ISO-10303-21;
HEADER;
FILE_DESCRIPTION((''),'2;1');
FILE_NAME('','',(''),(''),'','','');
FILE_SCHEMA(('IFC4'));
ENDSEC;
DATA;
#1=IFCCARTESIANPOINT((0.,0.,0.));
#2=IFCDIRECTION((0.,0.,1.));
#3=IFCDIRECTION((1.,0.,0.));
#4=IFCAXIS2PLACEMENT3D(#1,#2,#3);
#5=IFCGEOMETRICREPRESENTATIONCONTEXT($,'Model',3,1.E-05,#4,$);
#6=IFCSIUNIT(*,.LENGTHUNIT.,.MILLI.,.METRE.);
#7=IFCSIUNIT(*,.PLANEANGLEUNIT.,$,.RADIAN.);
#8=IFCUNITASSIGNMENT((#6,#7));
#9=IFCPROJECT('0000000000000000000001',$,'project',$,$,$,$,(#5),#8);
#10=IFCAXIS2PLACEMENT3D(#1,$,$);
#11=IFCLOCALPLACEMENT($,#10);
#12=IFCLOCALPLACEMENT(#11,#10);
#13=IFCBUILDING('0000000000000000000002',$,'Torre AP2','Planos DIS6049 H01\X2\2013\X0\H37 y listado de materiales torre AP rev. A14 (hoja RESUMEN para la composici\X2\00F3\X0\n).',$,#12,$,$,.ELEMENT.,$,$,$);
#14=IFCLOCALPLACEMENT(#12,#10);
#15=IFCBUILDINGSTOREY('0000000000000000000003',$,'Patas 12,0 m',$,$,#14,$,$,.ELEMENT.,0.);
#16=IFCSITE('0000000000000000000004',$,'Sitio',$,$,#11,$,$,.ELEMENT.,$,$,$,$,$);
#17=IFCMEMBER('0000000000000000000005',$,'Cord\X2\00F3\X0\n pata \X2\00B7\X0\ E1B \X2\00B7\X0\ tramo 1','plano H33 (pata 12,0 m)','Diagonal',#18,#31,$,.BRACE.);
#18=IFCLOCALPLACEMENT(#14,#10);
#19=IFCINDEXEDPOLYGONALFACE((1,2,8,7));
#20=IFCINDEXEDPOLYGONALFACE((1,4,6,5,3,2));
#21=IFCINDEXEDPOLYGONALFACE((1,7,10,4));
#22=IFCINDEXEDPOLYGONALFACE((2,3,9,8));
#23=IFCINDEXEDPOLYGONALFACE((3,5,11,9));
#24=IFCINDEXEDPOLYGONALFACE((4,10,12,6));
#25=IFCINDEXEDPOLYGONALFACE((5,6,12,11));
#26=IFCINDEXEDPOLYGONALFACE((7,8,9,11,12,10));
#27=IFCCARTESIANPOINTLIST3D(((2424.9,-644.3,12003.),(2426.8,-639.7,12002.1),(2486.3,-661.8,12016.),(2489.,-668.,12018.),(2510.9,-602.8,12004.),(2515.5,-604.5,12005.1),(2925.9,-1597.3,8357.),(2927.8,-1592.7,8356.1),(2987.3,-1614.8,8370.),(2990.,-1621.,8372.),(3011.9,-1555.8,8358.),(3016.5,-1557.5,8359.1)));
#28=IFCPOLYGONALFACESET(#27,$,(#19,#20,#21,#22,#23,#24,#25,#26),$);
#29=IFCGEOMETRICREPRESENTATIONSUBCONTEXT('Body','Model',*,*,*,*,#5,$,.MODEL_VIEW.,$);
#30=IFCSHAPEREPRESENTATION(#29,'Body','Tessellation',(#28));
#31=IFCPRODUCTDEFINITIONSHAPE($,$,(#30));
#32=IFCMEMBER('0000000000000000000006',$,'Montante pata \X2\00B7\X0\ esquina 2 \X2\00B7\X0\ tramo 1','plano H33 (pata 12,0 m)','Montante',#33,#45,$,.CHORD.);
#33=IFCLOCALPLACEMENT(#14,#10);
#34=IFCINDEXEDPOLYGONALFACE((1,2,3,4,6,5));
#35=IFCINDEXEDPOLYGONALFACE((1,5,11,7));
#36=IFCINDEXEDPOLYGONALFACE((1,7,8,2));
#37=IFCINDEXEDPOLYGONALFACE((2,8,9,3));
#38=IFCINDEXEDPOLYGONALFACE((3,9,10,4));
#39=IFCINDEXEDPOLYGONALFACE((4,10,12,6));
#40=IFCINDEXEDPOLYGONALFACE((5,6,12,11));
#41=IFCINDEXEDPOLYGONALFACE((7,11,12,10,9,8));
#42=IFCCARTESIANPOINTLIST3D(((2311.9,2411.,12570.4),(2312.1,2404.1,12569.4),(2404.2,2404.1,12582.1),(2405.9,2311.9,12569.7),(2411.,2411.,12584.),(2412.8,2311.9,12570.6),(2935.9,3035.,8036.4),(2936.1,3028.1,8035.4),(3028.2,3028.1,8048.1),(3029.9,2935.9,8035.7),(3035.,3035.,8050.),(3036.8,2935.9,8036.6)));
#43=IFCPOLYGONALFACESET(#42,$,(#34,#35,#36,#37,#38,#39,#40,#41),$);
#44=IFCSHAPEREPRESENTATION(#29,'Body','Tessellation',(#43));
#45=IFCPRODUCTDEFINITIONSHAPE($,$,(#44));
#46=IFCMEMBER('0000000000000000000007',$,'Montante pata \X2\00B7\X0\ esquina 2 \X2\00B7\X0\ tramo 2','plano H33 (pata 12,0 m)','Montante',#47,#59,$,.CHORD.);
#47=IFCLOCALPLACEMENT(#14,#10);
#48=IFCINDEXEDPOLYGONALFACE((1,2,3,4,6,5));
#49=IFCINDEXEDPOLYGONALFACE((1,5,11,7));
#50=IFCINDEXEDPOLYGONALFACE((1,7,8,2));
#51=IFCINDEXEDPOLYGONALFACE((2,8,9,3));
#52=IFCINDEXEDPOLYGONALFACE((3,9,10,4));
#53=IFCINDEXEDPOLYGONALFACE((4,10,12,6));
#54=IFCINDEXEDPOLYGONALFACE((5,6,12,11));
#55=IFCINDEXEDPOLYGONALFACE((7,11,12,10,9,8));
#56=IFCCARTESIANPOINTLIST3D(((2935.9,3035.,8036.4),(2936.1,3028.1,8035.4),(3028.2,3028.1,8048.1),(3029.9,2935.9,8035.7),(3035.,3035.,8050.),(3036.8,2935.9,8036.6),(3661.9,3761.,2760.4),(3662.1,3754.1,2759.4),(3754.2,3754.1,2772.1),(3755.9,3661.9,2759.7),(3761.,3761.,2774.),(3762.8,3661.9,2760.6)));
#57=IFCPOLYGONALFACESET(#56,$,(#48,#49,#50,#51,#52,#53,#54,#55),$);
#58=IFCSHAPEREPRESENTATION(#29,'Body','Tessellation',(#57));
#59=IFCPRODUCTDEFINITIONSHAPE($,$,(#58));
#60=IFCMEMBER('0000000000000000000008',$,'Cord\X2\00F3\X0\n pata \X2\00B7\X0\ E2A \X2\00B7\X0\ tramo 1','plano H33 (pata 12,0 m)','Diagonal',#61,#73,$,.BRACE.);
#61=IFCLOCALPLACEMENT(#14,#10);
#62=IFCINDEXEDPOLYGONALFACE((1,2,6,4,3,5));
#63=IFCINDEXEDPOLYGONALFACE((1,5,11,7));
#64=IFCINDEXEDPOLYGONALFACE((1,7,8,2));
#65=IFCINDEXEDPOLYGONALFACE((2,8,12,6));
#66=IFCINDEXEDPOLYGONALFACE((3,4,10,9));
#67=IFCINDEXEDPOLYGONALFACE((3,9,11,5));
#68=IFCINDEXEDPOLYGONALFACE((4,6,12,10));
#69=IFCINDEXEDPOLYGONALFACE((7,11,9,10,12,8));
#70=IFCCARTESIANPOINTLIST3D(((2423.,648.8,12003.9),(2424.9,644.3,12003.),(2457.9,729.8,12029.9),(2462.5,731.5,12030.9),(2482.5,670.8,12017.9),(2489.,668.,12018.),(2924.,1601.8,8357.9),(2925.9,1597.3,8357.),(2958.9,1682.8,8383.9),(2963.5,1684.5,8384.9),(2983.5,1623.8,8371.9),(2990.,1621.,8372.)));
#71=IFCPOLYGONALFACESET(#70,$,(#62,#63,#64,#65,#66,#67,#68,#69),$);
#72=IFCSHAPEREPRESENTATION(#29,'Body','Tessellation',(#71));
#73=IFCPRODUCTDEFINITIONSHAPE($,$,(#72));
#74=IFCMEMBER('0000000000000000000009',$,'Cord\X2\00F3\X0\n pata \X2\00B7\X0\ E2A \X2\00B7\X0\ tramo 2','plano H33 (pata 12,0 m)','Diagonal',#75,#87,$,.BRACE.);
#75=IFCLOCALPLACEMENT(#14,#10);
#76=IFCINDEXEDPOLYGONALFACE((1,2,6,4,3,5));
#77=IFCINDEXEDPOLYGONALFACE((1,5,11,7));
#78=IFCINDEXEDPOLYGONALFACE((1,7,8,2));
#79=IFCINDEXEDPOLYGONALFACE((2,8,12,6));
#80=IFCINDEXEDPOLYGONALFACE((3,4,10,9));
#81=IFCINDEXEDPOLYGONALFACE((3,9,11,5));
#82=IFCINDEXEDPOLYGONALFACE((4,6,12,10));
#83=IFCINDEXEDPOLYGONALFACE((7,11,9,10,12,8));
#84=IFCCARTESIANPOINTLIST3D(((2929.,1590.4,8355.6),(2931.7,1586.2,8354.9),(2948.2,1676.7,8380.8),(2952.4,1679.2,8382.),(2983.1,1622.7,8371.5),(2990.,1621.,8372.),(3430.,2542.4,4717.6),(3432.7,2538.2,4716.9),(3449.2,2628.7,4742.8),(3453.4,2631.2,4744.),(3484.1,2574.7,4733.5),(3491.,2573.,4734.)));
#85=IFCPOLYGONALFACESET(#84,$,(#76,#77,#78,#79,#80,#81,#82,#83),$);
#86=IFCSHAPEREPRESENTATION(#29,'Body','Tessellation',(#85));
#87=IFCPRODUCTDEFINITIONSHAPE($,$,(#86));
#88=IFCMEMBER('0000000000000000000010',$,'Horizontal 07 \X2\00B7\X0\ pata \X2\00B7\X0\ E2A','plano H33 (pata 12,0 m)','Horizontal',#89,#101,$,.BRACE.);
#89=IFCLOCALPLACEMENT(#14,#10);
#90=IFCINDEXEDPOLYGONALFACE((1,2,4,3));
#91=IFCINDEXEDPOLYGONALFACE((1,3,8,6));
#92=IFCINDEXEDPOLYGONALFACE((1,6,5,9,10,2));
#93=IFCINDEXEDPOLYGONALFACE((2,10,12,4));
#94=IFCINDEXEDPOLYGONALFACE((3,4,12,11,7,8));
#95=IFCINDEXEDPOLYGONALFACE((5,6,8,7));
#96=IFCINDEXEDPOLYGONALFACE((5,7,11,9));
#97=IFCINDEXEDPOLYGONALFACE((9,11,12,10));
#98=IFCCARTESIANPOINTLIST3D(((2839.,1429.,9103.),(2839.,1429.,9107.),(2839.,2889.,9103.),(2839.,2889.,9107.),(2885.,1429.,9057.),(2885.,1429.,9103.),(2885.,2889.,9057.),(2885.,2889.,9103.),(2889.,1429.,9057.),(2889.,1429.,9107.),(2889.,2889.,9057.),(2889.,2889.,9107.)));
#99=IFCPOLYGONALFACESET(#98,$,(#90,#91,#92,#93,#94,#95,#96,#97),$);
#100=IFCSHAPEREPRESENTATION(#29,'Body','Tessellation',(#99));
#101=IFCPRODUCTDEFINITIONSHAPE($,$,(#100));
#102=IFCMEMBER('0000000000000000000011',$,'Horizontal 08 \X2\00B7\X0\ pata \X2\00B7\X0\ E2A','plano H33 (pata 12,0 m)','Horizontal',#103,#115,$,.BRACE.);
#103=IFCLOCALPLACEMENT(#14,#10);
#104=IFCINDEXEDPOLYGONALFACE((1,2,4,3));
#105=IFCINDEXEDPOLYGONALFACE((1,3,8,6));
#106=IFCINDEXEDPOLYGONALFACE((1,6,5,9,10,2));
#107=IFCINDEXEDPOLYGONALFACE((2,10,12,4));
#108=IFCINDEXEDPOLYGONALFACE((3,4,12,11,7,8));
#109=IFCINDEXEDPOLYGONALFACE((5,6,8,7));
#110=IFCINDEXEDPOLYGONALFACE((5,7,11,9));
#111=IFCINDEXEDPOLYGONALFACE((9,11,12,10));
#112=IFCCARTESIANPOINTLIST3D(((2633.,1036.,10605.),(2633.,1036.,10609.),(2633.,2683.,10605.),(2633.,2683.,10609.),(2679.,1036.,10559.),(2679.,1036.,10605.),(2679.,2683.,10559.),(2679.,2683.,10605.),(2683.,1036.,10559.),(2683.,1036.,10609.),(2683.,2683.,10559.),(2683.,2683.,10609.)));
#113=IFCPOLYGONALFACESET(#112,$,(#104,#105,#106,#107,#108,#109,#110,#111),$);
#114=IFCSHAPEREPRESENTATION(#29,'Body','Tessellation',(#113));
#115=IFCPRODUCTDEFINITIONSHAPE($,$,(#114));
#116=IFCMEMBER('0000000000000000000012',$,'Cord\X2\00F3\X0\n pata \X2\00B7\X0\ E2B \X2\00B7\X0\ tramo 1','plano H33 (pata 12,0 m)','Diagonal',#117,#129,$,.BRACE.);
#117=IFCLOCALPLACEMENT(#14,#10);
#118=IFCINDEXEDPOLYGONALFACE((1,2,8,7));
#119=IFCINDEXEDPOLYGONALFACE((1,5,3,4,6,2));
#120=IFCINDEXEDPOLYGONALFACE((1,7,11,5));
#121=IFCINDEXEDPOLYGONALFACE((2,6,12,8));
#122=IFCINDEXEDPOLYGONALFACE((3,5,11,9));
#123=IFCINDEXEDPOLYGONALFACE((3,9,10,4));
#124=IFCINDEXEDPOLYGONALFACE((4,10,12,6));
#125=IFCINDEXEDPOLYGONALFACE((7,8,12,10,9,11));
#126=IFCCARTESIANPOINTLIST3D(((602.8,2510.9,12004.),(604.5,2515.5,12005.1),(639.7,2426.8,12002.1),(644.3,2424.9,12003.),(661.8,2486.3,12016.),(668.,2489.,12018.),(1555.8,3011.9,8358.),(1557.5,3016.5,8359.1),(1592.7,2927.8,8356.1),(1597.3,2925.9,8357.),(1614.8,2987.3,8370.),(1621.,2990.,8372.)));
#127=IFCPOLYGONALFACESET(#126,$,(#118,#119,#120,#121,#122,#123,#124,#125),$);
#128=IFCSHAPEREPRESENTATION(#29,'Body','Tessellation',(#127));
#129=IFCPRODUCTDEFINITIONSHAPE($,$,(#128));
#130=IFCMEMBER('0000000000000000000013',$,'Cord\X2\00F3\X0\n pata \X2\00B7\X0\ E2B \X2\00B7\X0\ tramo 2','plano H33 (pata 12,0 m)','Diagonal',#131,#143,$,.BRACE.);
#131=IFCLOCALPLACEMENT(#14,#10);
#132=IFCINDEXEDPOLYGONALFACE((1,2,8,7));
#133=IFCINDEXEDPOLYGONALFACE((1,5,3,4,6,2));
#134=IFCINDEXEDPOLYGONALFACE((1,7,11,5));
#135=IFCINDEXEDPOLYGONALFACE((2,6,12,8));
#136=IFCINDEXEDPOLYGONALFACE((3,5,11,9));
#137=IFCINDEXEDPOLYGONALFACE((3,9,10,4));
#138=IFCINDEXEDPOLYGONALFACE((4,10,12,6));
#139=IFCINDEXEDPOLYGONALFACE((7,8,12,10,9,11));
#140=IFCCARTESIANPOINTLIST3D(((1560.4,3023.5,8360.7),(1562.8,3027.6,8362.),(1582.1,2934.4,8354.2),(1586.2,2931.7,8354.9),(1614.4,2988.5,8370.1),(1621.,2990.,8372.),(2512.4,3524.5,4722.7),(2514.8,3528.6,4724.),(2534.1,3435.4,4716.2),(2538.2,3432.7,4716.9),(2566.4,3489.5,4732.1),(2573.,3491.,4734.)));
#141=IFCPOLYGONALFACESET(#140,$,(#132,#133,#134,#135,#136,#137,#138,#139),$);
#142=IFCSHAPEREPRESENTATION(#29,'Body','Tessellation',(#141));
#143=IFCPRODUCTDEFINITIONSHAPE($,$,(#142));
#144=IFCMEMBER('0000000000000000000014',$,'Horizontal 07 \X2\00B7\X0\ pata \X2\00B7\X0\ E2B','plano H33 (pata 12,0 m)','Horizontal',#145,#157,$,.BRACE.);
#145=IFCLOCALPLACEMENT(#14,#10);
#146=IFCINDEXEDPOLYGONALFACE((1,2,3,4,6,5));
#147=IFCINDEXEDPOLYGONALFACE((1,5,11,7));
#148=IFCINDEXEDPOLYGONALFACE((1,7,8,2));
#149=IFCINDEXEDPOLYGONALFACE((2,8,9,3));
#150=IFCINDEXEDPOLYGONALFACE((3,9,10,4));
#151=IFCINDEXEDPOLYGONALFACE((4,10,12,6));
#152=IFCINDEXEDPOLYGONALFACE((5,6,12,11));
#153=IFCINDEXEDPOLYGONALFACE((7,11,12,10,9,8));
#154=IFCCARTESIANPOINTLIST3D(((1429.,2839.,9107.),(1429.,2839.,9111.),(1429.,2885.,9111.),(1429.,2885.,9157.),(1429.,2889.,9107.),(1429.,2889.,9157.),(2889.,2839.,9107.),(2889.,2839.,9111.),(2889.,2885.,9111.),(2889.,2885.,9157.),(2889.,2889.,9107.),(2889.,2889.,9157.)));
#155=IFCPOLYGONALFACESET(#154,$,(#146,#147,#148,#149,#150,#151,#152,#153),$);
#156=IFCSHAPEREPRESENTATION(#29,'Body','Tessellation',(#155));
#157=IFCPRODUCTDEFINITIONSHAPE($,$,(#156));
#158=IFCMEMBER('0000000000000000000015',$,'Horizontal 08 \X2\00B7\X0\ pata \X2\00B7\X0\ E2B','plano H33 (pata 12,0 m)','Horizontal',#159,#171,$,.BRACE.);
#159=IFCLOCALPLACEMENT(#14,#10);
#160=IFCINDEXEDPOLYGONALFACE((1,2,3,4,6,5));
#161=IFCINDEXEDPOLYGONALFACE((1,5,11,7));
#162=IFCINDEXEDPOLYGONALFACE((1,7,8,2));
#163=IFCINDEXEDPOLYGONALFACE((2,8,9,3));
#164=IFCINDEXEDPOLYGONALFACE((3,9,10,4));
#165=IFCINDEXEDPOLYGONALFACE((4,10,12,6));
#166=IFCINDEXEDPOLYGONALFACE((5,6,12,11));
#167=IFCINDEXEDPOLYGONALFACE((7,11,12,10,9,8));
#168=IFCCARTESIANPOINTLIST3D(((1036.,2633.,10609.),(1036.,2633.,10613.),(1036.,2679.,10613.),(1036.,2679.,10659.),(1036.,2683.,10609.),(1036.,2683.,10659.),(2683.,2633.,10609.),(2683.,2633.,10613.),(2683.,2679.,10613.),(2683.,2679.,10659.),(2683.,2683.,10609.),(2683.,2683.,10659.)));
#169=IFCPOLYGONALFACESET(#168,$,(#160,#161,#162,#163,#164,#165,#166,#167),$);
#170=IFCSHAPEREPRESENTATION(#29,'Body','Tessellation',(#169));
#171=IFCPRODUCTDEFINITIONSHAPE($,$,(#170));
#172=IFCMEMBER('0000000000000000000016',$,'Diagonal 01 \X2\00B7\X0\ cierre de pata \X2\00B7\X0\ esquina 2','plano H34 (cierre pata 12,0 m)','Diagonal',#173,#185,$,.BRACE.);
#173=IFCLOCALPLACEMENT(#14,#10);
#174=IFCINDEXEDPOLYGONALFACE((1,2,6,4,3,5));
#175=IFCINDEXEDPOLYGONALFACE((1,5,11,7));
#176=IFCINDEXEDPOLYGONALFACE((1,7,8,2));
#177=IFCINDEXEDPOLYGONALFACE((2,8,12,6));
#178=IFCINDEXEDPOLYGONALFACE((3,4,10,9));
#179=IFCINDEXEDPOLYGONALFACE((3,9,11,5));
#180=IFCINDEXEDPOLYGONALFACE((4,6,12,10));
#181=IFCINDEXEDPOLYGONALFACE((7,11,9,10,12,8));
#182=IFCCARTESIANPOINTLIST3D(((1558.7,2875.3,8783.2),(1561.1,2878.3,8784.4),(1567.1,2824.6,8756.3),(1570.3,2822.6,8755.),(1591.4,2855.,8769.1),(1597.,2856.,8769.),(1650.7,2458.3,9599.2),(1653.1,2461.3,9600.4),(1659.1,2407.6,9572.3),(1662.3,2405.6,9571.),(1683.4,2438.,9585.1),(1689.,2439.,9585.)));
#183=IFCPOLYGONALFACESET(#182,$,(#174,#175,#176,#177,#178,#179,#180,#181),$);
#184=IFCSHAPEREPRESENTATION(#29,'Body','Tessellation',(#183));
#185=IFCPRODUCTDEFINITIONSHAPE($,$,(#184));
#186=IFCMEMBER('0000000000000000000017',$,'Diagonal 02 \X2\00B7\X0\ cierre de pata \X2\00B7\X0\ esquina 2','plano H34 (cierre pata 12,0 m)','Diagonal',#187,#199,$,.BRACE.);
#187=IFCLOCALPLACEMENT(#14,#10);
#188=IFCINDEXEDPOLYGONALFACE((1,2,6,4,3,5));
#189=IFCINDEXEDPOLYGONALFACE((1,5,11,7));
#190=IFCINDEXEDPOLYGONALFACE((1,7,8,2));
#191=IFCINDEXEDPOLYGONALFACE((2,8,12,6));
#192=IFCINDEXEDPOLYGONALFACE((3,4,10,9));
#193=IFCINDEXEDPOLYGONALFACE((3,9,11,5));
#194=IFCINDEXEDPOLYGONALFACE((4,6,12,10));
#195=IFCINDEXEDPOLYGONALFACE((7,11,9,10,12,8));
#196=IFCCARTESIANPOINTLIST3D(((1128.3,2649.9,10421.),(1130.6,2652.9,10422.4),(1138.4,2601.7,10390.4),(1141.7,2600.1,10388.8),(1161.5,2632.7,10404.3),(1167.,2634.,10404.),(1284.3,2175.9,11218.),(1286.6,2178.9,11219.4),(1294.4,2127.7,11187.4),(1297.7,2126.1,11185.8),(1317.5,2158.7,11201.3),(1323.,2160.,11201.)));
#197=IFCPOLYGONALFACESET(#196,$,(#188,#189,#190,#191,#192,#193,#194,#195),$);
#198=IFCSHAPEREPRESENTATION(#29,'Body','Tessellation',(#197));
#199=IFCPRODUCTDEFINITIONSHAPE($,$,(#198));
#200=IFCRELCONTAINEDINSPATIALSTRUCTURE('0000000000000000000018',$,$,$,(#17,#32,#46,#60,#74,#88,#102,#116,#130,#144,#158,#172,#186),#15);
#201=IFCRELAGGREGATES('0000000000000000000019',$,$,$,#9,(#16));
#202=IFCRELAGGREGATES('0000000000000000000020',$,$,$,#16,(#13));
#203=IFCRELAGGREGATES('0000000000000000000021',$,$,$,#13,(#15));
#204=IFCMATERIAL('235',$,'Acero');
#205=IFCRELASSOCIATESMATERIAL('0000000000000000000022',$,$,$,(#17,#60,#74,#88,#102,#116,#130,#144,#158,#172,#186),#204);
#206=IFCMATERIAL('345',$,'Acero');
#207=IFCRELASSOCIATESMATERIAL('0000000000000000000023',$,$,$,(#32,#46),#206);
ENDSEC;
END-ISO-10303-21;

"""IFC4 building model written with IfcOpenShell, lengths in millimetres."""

from ifc_helpers import new_model, si_unit, frame, frame_2d, origin, origin_with_axes, place, context, subcontext, project, spatial, l_section, extrude, material, element, save


model = new_model("IFC4")

# Units and contexts
model_context = context("Model", 3, precision=1e-05, world=origin_with_axes())
body_context = subcontext(model_context, "Body", "Model", "MODEL_VIEW")
ifc_project = project(units=[si_unit("LENGTHUNIT", "METRE", prefix="MILLI"), si_unit("PLANEANGLEUNIT", "RADIAN")], contexts=[model_context])

# Site, building, storey
site_placement = place(None, origin())
site = spatial("IfcSite", under=ifc_project, at=site_placement, Name="Sitio", CompositionType="ELEMENT")
building_placement = place(site_placement, origin())
building = spatial("IfcBuilding", under=site, at=building_placement, Name="Torre AP2", Description="Planos DIS6049 H01–H37 y listado de materiales torre AP rev. A14 (hoja RESUMEN para la composición).", CompositionType="ELEMENT")
storey_placement = place(building_placement, origin())
storey = spatial("IfcBuildingStorey", under=building, at=storey_placement, Name="Patas 12,0 m", CompositionType="ELEMENT", Elevation=0.0)

# Members
ifc_material_1 = material(Name="235", Category="Acero")
member_1_placement = place(storey_placement, frame((2489.0, -668.0, 12018.0), z_axis=(0.131785, -0.250681, -0.959058), x_axis=(-0.916032, 0.338951, -0.214469)))
element("IfcMember", 1, at=member_1_placement, inside=storey, material=ifc_material_1, Name="Cordón pata · E1B · tramo 1", Description="plano H33 (pata 12,0 m)", ObjectType="Diagonal", PredefinedType="BRACE", context=body_context, shape_type="SweptSolid", body=[
    extrude(l_section(Depth=70.0, Width=70.0, Thickness=5.0, at=frame_2d((35.0, 35.0))), None, (0.0, 0.0, 1.0), 3801.6),
])
ifc_material_2 = material(Name="345", Category="Acero")
member_2_placement = place(storey_placement, frame((2411.0, 2411.0, 12584.0), z_axis=(0.135092, 0.135092, -0.981581), x_axis=(0.018419, -0.990833, -0.13383)))
element("IfcMember", 2, at=member_2_placement, inside=storey, material=ifc_material_2, Name="Montante pata · esquina 2 · tramo 1", Description="plano H33 (pata 12,0 m)", ObjectType="Montante", PredefinedType="CHORD", context=body_context, shape_type="SweptSolid", body=[
    extrude(l_section(Depth=100.0, Width=100.0, Thickness=7.0, at=frame_2d((50.0, 50.0))), None, (0.0, 0.0, 1.0), 4619.1),
])
member_3_placement = place(storey_placement, frame((3035.0, 3035.0, 8050.0), z_axis=(0.13507, 0.13507, -0.981586), x_axis=(0.018413, -0.990836, -0.13381)))
element("IfcMember", 3, at=member_3_placement, inside=storey, material=ifc_material_2, Name="Montante pata · esquina 2 · tramo 2", Description="plano H33 (pata 12,0 m)", ObjectType="Montante", PredefinedType="CHORD", context=body_context, shape_type="SweptSolid", body=[
    extrude(l_section(Depth=100.0, Width=100.0, Thickness=7.0, at=frame_2d((50.0, 50.0))), None, (0.0, 0.0, 1.0), 5375.0),
])
member_4_placement = place(storey_placement, frame((2489.0, 668.0, 12018.0), z_axis=(0.131785, 0.250681, -0.959058), x_axis=(-0.916032, -0.338951, -0.214469)))
element("IfcMember", 4, at=member_4_placement, inside=storey, material=ifc_material_1, Name="Cordón pata · E2A · tramo 1", Description="plano H33 (pata 12,0 m)", ObjectType="Diagonal", PredefinedType="BRACE", context=body_context, shape_type="SweptSolid", body=[
    extrude(l_section(Depth=70.0, Width=70.0, Thickness=5.0, at=frame_2d((35.0, 35.0))), None, (0.0, 0.0, 1.0), 3801.6),
])
member_5_placement = place(storey_placement, frame((2990.0, 1621.0, 8372.0), z_axis=(0.13206, 0.250941, -0.958952), x_axis=(-0.832746, -0.49667, -0.24465)))
element("IfcMember", 5, at=member_5_placement, inside=storey, material=ifc_material_1, Name="Cordón pata · E2A · tramo 2", Description="plano H33 (pata 12,0 m)", ObjectType="Diagonal", PredefinedType="BRACE", context=body_context, shape_type="SweptSolid", body=[
    extrude(l_section(Depth=70.0, Width=70.0, Thickness=5.0, at=frame_2d((35.0, 35.0))), None, (0.0, 0.0, 1.0), 3793.7),
])
member_6_placement = place(storey_placement, frame((2889.0, 2889.0, 9107.0), z_axis=(0.0, -1.0, 0.0), x_axis=(-1.0, 0.0, 0.0)))
element("IfcMember", 6, at=member_6_placement, inside=storey, material=ifc_material_1, Name="Horizontal 07 · pata · E2A", Description="plano H33 (pata 12,0 m)", ObjectType="Horizontal", PredefinedType="BRACE", context=body_context, shape_type="SweptSolid", body=[
    extrude(l_section(Depth=50.0, Width=50.0, Thickness=4.0, at=frame_2d((25.0, 25.0))), None, (0.0, 0.0, 1.0), 1460.0),
])
member_7_placement = place(storey_placement, frame((2683.0, 2683.0, 10609.0), z_axis=(0.0, -1.0, 0.0), x_axis=(-1.0, 0.0, 0.0)))
element("IfcMember", 7, at=member_7_placement, inside=storey, material=ifc_material_1, Name="Horizontal 08 · pata · E2A", Description="plano H33 (pata 12,0 m)", ObjectType="Horizontal", PredefinedType="BRACE", context=body_context, shape_type="SweptSolid", body=[
    extrude(l_section(Depth=50.0, Width=50.0, Thickness=4.0, at=frame_2d((25.0, 25.0))), None, (0.0, 0.0, 1.0), 1647.0),
])
member_8_placement = place(storey_placement, frame((668.0, 2489.0, 12018.0), z_axis=(0.250681, 0.131785, -0.959058), x_axis=(-0.338951, -0.916032, -0.214469)))
element("IfcMember", 8, at=member_8_placement, inside=storey, material=ifc_material_1, Name="Cordón pata · E2B · tramo 1", Description="plano H33 (pata 12,0 m)", ObjectType="Diagonal", PredefinedType="BRACE", context=body_context, shape_type="SweptSolid", body=[
    extrude(l_section(Depth=70.0, Width=70.0, Thickness=5.0, at=frame_2d((35.0, 35.0))), None, (0.0, 0.0, 1.0), 3801.6),
])
member_9_placement = place(storey_placement, frame((1621.0, 2990.0, 8372.0), z_axis=(0.250941, 0.13206, -0.958952), x_axis=(-0.49667, -0.832746, -0.24465)))
element("IfcMember", 9, at=member_9_placement, inside=storey, material=ifc_material_1, Name="Cordón pata · E2B · tramo 2", Description="plano H33 (pata 12,0 m)", ObjectType="Diagonal", PredefinedType="BRACE", context=body_context, shape_type="SweptSolid", body=[
    extrude(l_section(Depth=70.0, Width=70.0, Thickness=5.0, at=frame_2d((35.0, 35.0))), None, (0.0, 0.0, 1.0), 3793.7),
])
member_10_placement = place(storey_placement, frame((2889.0, 2889.0, 9107.0), z_axis=(-1.0, 0.0, 0.0), x_axis=(0.0, -1.0, 0.0)))
element("IfcMember", 10, at=member_10_placement, inside=storey, material=ifc_material_1, Name="Horizontal 07 · pata · E2B", Description="plano H33 (pata 12,0 m)", ObjectType="Horizontal", PredefinedType="BRACE", context=body_context, shape_type="SweptSolid", body=[
    extrude(l_section(Depth=50.0, Width=50.0, Thickness=4.0, at=frame_2d((25.0, 25.0))), None, (0.0, 0.0, 1.0), 1460.0),
])
member_11_placement = place(storey_placement, frame((2683.0, 2683.0, 10609.0), z_axis=(-1.0, 0.0, 0.0), x_axis=(0.0, -1.0, 0.0)))
element("IfcMember", 11, at=member_11_placement, inside=storey, material=ifc_material_1, Name="Horizontal 08 · pata · E2B", Description="plano H33 (pata 12,0 m)", ObjectType="Horizontal", PredefinedType="BRACE", context=body_context, shape_type="SweptSolid", body=[
    extrude(l_section(Depth=50.0, Width=50.0, Thickness=4.0, at=frame_2d((25.0, 25.0))), None, (0.0, 0.0, 1.0), 1647.0),
])
member_12_placement = place(storey_placement, frame((1689.0, 2439.0, 9585.0), z_axis=(-0.099893, 0.452777, -0.88601), x_axis=(-0.594179, -0.741403, -0.311888)))
element("IfcMember", 12, at=member_12_placement, inside=storey, material=ifc_material_1, Name="Diagonal 01 · cierre de pata · esquina 2", Description="plano H34 (cierre pata 12,0 m)", ObjectType="Diagonal", PredefinedType="BRACE", context=body_context, shape_type="SweptSolid", body=[
    extrude(l_section(Depth=45.0, Width=45.0, Thickness=4.0, at=frame_2d((22.5, 22.5))), None, (0.0, 0.0, 1.0), 921.0),
])
member_13_placement = place(storey_placement, frame((1323.0, 2160.0, 11201.0), z_axis=(-0.165899, 0.504078, -0.847575), x_axis=(-0.56258, -0.754279, -0.338477)))
element("IfcMember", 13, at=member_13_placement, inside=storey, material=ifc_material_1, Name="Diagonal 02 · cierre de pata · esquina 2", Description="plano H34 (cierre pata 12,0 m)", ObjectType="Diagonal", PredefinedType="BRACE", context=body_context, shape_type="SweptSolid", body=[
    extrude(l_section(Depth=45.0, Width=45.0, Thickness=4.0, at=frame_2d((22.5, 22.5))), None, (0.0, 0.0, 1.0), 940.3),
])

save(model, "model.ifc")
